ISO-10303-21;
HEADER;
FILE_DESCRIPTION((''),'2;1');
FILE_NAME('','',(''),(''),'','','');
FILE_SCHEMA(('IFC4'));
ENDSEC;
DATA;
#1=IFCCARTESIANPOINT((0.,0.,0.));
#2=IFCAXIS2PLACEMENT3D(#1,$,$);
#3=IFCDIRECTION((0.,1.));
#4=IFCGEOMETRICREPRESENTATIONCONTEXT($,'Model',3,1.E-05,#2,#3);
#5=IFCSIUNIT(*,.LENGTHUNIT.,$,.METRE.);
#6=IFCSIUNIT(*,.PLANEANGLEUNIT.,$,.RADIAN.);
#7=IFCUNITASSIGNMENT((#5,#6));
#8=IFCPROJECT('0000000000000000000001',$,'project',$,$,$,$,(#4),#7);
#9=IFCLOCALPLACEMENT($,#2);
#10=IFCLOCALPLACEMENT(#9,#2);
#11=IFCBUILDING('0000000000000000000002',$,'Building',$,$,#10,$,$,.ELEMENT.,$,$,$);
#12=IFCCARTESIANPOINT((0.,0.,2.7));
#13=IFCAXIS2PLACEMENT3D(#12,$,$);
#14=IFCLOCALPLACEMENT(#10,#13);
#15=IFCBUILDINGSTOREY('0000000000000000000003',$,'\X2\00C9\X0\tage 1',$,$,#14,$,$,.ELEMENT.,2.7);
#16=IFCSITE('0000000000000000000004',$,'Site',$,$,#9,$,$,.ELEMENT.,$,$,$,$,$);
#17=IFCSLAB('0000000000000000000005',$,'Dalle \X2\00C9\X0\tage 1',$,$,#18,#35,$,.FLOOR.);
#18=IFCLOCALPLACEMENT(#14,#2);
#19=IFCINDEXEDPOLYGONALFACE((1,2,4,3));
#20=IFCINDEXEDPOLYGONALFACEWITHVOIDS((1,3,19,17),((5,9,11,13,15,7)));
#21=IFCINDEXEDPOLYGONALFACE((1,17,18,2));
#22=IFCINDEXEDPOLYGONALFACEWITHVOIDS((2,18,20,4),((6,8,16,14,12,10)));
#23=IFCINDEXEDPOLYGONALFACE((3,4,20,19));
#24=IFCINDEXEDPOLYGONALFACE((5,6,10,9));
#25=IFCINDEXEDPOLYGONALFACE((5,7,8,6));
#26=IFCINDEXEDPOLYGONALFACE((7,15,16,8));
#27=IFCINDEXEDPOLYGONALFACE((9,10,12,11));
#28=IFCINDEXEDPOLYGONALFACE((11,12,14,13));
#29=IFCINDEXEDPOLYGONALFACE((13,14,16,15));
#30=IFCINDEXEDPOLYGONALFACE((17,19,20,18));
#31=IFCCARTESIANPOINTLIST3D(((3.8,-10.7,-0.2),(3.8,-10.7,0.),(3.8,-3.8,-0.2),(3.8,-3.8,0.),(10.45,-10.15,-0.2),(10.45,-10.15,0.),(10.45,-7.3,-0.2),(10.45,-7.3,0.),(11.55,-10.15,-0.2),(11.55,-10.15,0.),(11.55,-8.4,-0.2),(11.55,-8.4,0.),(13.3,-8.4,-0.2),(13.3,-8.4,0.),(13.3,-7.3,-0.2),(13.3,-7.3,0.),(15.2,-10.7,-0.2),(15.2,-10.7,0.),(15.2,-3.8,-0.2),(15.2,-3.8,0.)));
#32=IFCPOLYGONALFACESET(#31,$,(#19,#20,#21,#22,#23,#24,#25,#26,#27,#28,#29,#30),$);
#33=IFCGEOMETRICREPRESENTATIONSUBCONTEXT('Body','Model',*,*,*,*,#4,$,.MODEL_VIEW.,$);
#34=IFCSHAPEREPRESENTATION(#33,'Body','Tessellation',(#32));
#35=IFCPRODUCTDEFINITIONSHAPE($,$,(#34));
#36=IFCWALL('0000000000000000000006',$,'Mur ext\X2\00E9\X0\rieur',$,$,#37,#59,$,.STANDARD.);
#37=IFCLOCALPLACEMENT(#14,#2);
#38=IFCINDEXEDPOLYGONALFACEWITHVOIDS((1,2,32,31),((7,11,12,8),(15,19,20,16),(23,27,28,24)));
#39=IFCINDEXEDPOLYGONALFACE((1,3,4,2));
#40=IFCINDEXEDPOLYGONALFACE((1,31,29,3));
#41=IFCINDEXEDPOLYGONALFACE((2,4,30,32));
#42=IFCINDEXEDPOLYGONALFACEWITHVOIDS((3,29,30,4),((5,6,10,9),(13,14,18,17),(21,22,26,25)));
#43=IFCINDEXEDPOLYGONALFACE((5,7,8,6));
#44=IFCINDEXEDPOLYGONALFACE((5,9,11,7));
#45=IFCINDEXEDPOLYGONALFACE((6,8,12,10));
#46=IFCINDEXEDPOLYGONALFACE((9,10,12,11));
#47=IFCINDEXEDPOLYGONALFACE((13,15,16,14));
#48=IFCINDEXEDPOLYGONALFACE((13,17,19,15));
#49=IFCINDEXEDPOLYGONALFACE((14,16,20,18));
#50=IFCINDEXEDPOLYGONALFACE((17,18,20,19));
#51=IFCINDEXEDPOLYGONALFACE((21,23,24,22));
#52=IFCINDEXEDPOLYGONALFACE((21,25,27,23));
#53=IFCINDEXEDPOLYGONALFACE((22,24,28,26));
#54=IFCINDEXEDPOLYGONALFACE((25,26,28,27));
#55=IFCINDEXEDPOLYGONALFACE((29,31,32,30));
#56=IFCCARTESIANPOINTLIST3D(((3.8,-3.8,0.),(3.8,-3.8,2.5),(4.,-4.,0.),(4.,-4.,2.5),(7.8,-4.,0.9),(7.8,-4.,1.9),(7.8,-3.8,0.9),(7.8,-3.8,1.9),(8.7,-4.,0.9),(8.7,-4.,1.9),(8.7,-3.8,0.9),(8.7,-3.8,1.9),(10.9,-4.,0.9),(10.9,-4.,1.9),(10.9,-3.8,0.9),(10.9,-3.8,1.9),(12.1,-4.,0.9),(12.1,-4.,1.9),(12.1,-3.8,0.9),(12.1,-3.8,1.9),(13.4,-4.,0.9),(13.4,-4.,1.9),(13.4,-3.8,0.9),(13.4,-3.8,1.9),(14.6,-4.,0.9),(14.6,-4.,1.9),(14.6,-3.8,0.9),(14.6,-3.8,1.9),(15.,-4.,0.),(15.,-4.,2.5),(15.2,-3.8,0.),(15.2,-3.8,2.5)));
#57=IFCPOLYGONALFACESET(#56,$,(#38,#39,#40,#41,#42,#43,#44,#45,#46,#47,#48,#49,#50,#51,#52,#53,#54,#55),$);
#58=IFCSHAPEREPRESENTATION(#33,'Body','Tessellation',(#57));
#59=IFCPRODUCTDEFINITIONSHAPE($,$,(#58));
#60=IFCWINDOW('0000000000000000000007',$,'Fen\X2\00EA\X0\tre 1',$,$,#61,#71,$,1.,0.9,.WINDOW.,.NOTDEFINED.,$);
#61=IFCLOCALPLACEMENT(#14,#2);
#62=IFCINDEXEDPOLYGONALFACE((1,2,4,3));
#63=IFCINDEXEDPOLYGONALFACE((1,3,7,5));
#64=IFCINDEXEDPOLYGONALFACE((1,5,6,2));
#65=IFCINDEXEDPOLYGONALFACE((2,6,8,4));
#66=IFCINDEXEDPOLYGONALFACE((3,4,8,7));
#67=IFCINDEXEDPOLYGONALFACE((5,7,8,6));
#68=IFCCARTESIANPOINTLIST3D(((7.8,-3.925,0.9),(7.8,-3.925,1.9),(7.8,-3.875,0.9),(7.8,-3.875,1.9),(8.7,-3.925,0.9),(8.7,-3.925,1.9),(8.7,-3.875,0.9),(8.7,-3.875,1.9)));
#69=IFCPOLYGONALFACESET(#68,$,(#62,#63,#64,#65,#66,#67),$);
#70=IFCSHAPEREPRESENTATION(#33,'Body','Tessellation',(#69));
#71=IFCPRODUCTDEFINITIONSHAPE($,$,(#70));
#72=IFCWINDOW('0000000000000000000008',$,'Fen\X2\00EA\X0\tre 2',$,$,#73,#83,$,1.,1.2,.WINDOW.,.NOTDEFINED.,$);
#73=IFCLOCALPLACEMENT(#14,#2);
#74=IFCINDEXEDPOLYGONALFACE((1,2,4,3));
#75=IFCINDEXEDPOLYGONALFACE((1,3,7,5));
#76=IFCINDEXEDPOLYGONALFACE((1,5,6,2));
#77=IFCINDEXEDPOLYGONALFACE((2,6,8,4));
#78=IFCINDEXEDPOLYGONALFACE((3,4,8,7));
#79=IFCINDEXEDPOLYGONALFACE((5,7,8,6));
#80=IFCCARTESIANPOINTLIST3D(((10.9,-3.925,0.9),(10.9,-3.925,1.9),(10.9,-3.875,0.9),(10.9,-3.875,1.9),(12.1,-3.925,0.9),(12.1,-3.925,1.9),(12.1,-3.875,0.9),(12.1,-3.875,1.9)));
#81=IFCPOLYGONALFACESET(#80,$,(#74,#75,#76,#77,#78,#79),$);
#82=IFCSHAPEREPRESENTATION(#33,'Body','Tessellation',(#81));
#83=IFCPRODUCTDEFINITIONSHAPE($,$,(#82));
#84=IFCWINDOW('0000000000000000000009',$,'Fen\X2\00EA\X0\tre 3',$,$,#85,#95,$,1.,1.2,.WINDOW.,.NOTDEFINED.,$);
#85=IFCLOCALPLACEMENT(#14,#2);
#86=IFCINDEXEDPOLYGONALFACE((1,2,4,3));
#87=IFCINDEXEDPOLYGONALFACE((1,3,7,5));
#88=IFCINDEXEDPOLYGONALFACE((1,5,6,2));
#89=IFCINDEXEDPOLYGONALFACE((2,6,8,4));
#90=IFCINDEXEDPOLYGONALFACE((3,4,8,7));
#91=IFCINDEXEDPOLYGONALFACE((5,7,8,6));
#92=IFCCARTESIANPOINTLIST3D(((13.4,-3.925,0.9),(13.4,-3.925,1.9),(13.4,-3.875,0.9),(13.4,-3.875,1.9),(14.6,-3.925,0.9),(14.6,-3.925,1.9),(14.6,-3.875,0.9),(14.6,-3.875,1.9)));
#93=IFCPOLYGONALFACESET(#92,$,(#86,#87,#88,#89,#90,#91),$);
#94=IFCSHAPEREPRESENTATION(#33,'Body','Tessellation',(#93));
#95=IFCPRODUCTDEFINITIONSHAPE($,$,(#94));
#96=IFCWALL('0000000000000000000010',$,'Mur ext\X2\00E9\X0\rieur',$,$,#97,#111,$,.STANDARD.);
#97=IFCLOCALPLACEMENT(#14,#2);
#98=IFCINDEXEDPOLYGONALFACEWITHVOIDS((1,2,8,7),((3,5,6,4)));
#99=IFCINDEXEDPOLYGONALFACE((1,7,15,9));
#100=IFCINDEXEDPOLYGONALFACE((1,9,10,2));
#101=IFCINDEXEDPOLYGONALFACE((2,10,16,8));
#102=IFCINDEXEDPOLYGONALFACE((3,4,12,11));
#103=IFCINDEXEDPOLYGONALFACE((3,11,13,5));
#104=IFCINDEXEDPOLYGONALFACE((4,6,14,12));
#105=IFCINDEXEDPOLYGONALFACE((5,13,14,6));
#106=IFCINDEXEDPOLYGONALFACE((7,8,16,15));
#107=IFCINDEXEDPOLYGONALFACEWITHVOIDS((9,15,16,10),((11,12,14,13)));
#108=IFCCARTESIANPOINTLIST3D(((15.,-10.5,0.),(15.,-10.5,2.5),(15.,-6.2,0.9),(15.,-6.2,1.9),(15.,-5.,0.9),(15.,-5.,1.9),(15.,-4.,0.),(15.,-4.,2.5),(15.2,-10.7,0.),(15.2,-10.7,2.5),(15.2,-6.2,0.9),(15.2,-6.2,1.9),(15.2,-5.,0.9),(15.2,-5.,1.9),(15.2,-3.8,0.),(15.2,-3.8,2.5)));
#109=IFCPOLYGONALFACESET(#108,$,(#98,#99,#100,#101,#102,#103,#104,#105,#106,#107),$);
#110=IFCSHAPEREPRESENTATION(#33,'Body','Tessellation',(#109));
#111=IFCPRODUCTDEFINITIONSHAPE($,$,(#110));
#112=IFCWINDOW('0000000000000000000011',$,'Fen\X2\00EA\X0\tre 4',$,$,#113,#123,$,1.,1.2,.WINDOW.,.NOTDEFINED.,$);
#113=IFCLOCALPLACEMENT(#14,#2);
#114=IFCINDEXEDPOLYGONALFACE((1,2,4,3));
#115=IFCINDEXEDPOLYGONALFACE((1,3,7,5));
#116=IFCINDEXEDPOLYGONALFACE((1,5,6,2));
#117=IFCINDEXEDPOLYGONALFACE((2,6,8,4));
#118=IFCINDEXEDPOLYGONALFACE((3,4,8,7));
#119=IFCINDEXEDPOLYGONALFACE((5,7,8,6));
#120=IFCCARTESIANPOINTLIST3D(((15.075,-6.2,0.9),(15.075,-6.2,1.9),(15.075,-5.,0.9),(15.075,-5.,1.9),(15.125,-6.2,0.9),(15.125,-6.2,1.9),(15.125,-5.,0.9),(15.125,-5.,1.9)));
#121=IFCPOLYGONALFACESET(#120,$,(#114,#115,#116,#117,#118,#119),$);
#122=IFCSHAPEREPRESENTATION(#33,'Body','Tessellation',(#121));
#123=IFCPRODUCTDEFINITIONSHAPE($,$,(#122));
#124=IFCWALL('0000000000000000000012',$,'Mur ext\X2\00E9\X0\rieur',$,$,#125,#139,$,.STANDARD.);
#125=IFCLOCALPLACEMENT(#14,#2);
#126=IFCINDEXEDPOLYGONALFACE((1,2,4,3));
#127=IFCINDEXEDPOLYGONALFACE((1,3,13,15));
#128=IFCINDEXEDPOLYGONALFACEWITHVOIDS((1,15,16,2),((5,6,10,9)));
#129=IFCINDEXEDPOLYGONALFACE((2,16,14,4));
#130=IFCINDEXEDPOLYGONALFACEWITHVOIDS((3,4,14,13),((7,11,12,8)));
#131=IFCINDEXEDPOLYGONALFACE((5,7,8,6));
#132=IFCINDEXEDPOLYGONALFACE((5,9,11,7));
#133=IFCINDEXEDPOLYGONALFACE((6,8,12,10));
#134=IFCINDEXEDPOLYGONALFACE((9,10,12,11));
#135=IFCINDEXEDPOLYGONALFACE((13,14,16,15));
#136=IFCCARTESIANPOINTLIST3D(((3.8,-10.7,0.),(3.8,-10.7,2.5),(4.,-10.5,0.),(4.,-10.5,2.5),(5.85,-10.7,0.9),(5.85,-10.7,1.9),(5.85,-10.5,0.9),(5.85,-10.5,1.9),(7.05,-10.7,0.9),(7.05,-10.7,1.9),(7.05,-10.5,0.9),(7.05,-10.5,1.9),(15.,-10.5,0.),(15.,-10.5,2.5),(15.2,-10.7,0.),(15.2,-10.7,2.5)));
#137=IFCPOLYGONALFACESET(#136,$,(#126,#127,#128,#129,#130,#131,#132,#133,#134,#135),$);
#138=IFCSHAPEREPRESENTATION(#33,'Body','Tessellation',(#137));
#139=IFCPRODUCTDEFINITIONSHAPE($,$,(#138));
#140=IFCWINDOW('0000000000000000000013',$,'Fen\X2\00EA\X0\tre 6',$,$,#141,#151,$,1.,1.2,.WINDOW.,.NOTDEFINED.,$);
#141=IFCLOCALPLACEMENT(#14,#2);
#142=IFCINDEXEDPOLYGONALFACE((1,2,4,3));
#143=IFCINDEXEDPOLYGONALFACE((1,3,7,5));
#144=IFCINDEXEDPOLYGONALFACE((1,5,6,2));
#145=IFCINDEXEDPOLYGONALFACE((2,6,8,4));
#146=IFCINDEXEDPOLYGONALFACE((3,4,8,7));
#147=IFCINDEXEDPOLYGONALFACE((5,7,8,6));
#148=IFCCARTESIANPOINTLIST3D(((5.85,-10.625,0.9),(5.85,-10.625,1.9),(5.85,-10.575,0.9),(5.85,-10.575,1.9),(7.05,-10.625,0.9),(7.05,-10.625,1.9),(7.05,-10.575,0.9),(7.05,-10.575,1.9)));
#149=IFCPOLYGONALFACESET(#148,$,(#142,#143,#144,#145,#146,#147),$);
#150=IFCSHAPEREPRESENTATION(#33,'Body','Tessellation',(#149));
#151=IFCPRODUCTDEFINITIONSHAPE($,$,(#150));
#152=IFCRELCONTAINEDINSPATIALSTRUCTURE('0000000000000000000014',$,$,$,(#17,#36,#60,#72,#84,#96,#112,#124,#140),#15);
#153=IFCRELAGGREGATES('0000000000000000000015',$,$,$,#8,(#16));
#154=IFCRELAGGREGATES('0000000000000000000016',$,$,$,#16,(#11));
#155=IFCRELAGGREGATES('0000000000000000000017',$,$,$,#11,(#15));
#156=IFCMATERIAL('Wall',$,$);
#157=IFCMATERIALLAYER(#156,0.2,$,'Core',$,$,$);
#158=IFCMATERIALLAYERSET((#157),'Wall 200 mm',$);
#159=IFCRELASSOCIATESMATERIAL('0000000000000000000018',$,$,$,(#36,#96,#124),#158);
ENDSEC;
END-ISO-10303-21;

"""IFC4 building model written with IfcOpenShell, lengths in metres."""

from ifc_helpers import new_model, si_unit, direction, frame, origin, origin_2d, place, context, subcontext, project, spatial, polyline, rectangle, outline, extrude, material, layer, layer_set, layer_usage, element, fill, save


model = new_model("IFC4")

# Units and contexts
model_context = context("Model", 3, precision=1e-05, world=origin(), true_north=direction((0.0, 1.0)))
body_context = subcontext(model_context, "Body", "Model", "MODEL_VIEW")
ifc_project = project(units=[si_unit("LENGTHUNIT", "METRE"), si_unit("PLANEANGLEUNIT", "RADIAN")], contexts=[model_context])

# Site, building, storey
site_placement = place(None, origin())
site = spatial("IfcSite", under=ifc_project, at=site_placement, Name="Site", CompositionType="ELEMENT")
building_placement = place(site_placement, origin())
building = spatial("IfcBuilding", under=site, at=building_placement, Name="Building", CompositionType="ELEMENT")
storey_placement = place(building_placement, frame((0.0, 0.0, 2.7)))
storey = spatial("IfcBuildingStorey", under=building, at=storey_placement, Name="Étage 1", CompositionType="ELEMENT", Elevation=2.7)

# Slab
slab_placement = place(storey_placement, origin())
element("IfcSlab", 1, at=slab_placement, inside=storey, Name="Dalle Étage 1", PredefinedType="FLOOR", context=body_context, shape_type="SweptSolid", body=[
    extrude(outline(polyline([(3.8, -10.7), (15.2, -10.7), (15.2, -3.8), (3.8, -3.8), (3.8, -10.7)]), holes=[polyline([(13.3, -7.3), (13.3, -8.4), (11.55, -8.4), (11.55, -10.15), (10.45, -10.15), (10.45, -7.3), (13.3, -7.3)])]), frame((0.0, 0.0, -0.2)), (0.0, 0.0, 1.0), 0.2),
])

# Wall, openings, windows
ifc_material = material(Name="Wall")
ifc_layer = layer(ifc_material, 0.2, Name="Core")
ifc_layer_set = layer_set([ifc_layer], Name="Wall 200 mm")
ifc_layer_usage = layer_usage(ifc_layer_set, "AXIS2", "POSITIVE", -0.1)
wall_1_placement = place(storey_placement, frame((3.9, -3.9, 0.0)))
wall_1 = element("IfcWall", 2, at=wall_1_placement, inside=storey, material=ifc_layer_usage, Name="Mur extérieur", PredefinedType="STANDARD", context=body_context, shape_type="SweptSolid", body=[
    extrude(outline(polyline([(0.0, 0.0), (0.1, -0.1), (11.1, -0.1), (11.2, 0.0), (11.3, 0.1), (-0.1, 0.1), (0.0, 0.0)])), origin(), (0.0, 0.0, 1.0), 2.5),
])
opening_1_placement = place(wall_1_placement, frame((4.35, 0.0, 0.9)))
opening_1 = element("IfcOpeningElement", 3, at=opening_1_placement, cuts=wall_1, PredefinedType="OPENING", context=body_context, shape_type="SweptSolid", body=[
    extrude(rectangle(XDim=0.9, YDim=0.4, at=origin_2d()), origin(), (0.0, 0.0, 1.0), 1.0),
])
opening_2_placement = place(wall_1_placement, frame((7.6, 0.0, 0.9)))
opening_2 = element("IfcOpeningElement", 4, at=opening_2_placement, cuts=wall_1, PredefinedType="OPENING", context=body_context, shape_type="SweptSolid", body=[
    extrude(rectangle(XDim=1.2, YDim=0.4, at=origin_2d()), origin(), (0.0, 0.0, 1.0), 1.0),
])
opening_3_placement = place(wall_1_placement, frame((10.1, 0.0, 0.9)))
opening_3 = element("IfcOpeningElement", 5, at=opening_3_placement, cuts=wall_1, PredefinedType="OPENING", context=body_context, shape_type="SweptSolid", body=[
    extrude(rectangle(XDim=1.2, YDim=0.4, at=origin_2d()), origin(), (0.0, 0.0, 1.0), 1.0),
])
window_1_placement = place(opening_1_placement, origin())
window_1 = element("IfcWindow", 6, at=window_1_placement, inside=storey, Name="Fenêtre 1", OverallHeight=1.0, OverallWidth=0.9, PartitioningType="NOTDEFINED", PredefinedType="WINDOW", context=body_context, shape_type="SweptSolid", body=[
    extrude(rectangle(XDim=0.9, YDim=0.05, at=origin_2d()), origin(), (0.0, 0.0, 1.0), 1.0),
])
fill(opening_1, window_1)
window_2_placement = place(opening_2_placement, origin())
window_2 = element("IfcWindow", 7, at=window_2_placement, inside=storey, Name="Fenêtre 2", OverallHeight=1.0, OverallWidth=1.2, PartitioningType="NOTDEFINED", PredefinedType="WINDOW", context=body_context, shape_type="SweptSolid", body=[
    extrude(rectangle(XDim=1.2, YDim=0.05, at=origin_2d()), origin(), (0.0, 0.0, 1.0), 1.0),
])
fill(opening_2, window_2)
window_3_placement = place(opening_3_placement, origin())
window_3 = element("IfcWindow", 8, at=window_3_placement, inside=storey, Name="Fenêtre 3", OverallHeight=1.0, OverallWidth=1.2, PartitioningType="NOTDEFINED", PredefinedType="WINDOW", context=body_context, shape_type="SweptSolid", body=[
    extrude(rectangle(XDim=1.2, YDim=0.05, at=origin_2d()), origin(), (0.0, 0.0, 1.0), 1.0),
])
fill(opening_3, window_3)

# Walls, openings, windows
wall_2_placement = place(storey_placement, frame((15.1, -3.9, 0.0), z_axis=(0.0, 0.0, 1.0), x_axis=(0.0, -1.0, 0.0)))
wall_2 = element("IfcWall", 9, at=wall_2_placement, inside=storey, material=ifc_layer_usage, Name="Mur extérieur", PredefinedType="STANDARD", context=body_context, shape_type="SweptSolid", body=[
    extrude(outline(polyline([(0.0, 0.0), (0.1, -0.1), (6.6, -0.1), (6.7, 0.0), (6.8, 0.1), (-0.1, 0.1), (0.0, 0.0)])), origin(), (0.0, 0.0, 1.0), 2.5),
])
opening_4_placement = place(wall_2_placement, frame((1.7, 0.0, 0.9)))
opening_4 = element("IfcOpeningElement", 10, at=opening_4_placement, cuts=wall_2, PredefinedType="OPENING", context=body_context, shape_type="SweptSolid", body=[
    extrude(rectangle(XDim=1.2, YDim=0.4, at=origin_2d()), origin(), (0.0, 0.0, 1.0), 1.0),
])
window_4_placement = place(opening_4_placement, origin())
window_4 = element("IfcWindow", 11, at=window_4_placement, inside=storey, Name="Fenêtre 4", OverallHeight=1.0, OverallWidth=1.2, PartitioningType="NOTDEFINED", PredefinedType="WINDOW", context=body_context, shape_type="SweptSolid", body=[
    extrude(rectangle(XDim=1.2, YDim=0.05, at=origin_2d()), origin(), (0.0, 0.0, 1.0), 1.0),
])
fill(opening_4, window_4)
wall_3_placement = place(storey_placement, frame((15.1, -10.6, 0.0), z_axis=(0.0, 0.0, 1.0), x_axis=(-1.0, 0.0, 0.0)))
wall_3 = element("IfcWall", 12, at=wall_3_placement, inside=storey, material=ifc_layer_usage, Name="Mur extérieur", PredefinedType="STANDARD", context=body_context, shape_type="SweptSolid", body=[
    extrude(outline(polyline([(0.0, 0.0), (0.1, -0.1), (11.1, -0.1), (11.2, 0.0), (11.3, 0.1), (-0.1, 0.1), (0.0, 0.0)])), origin(), (0.0, 0.0, 1.0), 2.5),
])
opening_5_placement = place(wall_3_placement, frame((8.65, 0.0, 0.9), z_axis=(0.0, 0.0, 1.0), x_axis=(1.0, 0.0, 0.0)))
opening_5 = element("IfcOpeningElement", 13, at=opening_5_placement, cuts=wall_3, PredefinedType="OPENING", context=body_context, shape_type="SweptSolid", body=[
    extrude(rectangle(XDim=1.2, YDim=0.4, at=origin_2d()), origin(), (0.0, 0.0, 1.0), 1.0),
])
window_5_placement = place(opening_5_placement, origin())
window_5 = element("IfcWindow", 14, at=window_5_placement, inside=storey, Name="Fenêtre 6", OverallHeight=1.0, OverallWidth=1.2, PartitioningType="NOTDEFINED", PredefinedType="WINDOW", context=body_context, shape_type="SweptSolid", body=[
    extrude(rectangle(XDim=1.2, YDim=0.05, at=origin_2d()), origin(), (0.0, 0.0, 1.0), 1.0),
])
fill(opening_5, window_5)

save(model, "model.ifc")
